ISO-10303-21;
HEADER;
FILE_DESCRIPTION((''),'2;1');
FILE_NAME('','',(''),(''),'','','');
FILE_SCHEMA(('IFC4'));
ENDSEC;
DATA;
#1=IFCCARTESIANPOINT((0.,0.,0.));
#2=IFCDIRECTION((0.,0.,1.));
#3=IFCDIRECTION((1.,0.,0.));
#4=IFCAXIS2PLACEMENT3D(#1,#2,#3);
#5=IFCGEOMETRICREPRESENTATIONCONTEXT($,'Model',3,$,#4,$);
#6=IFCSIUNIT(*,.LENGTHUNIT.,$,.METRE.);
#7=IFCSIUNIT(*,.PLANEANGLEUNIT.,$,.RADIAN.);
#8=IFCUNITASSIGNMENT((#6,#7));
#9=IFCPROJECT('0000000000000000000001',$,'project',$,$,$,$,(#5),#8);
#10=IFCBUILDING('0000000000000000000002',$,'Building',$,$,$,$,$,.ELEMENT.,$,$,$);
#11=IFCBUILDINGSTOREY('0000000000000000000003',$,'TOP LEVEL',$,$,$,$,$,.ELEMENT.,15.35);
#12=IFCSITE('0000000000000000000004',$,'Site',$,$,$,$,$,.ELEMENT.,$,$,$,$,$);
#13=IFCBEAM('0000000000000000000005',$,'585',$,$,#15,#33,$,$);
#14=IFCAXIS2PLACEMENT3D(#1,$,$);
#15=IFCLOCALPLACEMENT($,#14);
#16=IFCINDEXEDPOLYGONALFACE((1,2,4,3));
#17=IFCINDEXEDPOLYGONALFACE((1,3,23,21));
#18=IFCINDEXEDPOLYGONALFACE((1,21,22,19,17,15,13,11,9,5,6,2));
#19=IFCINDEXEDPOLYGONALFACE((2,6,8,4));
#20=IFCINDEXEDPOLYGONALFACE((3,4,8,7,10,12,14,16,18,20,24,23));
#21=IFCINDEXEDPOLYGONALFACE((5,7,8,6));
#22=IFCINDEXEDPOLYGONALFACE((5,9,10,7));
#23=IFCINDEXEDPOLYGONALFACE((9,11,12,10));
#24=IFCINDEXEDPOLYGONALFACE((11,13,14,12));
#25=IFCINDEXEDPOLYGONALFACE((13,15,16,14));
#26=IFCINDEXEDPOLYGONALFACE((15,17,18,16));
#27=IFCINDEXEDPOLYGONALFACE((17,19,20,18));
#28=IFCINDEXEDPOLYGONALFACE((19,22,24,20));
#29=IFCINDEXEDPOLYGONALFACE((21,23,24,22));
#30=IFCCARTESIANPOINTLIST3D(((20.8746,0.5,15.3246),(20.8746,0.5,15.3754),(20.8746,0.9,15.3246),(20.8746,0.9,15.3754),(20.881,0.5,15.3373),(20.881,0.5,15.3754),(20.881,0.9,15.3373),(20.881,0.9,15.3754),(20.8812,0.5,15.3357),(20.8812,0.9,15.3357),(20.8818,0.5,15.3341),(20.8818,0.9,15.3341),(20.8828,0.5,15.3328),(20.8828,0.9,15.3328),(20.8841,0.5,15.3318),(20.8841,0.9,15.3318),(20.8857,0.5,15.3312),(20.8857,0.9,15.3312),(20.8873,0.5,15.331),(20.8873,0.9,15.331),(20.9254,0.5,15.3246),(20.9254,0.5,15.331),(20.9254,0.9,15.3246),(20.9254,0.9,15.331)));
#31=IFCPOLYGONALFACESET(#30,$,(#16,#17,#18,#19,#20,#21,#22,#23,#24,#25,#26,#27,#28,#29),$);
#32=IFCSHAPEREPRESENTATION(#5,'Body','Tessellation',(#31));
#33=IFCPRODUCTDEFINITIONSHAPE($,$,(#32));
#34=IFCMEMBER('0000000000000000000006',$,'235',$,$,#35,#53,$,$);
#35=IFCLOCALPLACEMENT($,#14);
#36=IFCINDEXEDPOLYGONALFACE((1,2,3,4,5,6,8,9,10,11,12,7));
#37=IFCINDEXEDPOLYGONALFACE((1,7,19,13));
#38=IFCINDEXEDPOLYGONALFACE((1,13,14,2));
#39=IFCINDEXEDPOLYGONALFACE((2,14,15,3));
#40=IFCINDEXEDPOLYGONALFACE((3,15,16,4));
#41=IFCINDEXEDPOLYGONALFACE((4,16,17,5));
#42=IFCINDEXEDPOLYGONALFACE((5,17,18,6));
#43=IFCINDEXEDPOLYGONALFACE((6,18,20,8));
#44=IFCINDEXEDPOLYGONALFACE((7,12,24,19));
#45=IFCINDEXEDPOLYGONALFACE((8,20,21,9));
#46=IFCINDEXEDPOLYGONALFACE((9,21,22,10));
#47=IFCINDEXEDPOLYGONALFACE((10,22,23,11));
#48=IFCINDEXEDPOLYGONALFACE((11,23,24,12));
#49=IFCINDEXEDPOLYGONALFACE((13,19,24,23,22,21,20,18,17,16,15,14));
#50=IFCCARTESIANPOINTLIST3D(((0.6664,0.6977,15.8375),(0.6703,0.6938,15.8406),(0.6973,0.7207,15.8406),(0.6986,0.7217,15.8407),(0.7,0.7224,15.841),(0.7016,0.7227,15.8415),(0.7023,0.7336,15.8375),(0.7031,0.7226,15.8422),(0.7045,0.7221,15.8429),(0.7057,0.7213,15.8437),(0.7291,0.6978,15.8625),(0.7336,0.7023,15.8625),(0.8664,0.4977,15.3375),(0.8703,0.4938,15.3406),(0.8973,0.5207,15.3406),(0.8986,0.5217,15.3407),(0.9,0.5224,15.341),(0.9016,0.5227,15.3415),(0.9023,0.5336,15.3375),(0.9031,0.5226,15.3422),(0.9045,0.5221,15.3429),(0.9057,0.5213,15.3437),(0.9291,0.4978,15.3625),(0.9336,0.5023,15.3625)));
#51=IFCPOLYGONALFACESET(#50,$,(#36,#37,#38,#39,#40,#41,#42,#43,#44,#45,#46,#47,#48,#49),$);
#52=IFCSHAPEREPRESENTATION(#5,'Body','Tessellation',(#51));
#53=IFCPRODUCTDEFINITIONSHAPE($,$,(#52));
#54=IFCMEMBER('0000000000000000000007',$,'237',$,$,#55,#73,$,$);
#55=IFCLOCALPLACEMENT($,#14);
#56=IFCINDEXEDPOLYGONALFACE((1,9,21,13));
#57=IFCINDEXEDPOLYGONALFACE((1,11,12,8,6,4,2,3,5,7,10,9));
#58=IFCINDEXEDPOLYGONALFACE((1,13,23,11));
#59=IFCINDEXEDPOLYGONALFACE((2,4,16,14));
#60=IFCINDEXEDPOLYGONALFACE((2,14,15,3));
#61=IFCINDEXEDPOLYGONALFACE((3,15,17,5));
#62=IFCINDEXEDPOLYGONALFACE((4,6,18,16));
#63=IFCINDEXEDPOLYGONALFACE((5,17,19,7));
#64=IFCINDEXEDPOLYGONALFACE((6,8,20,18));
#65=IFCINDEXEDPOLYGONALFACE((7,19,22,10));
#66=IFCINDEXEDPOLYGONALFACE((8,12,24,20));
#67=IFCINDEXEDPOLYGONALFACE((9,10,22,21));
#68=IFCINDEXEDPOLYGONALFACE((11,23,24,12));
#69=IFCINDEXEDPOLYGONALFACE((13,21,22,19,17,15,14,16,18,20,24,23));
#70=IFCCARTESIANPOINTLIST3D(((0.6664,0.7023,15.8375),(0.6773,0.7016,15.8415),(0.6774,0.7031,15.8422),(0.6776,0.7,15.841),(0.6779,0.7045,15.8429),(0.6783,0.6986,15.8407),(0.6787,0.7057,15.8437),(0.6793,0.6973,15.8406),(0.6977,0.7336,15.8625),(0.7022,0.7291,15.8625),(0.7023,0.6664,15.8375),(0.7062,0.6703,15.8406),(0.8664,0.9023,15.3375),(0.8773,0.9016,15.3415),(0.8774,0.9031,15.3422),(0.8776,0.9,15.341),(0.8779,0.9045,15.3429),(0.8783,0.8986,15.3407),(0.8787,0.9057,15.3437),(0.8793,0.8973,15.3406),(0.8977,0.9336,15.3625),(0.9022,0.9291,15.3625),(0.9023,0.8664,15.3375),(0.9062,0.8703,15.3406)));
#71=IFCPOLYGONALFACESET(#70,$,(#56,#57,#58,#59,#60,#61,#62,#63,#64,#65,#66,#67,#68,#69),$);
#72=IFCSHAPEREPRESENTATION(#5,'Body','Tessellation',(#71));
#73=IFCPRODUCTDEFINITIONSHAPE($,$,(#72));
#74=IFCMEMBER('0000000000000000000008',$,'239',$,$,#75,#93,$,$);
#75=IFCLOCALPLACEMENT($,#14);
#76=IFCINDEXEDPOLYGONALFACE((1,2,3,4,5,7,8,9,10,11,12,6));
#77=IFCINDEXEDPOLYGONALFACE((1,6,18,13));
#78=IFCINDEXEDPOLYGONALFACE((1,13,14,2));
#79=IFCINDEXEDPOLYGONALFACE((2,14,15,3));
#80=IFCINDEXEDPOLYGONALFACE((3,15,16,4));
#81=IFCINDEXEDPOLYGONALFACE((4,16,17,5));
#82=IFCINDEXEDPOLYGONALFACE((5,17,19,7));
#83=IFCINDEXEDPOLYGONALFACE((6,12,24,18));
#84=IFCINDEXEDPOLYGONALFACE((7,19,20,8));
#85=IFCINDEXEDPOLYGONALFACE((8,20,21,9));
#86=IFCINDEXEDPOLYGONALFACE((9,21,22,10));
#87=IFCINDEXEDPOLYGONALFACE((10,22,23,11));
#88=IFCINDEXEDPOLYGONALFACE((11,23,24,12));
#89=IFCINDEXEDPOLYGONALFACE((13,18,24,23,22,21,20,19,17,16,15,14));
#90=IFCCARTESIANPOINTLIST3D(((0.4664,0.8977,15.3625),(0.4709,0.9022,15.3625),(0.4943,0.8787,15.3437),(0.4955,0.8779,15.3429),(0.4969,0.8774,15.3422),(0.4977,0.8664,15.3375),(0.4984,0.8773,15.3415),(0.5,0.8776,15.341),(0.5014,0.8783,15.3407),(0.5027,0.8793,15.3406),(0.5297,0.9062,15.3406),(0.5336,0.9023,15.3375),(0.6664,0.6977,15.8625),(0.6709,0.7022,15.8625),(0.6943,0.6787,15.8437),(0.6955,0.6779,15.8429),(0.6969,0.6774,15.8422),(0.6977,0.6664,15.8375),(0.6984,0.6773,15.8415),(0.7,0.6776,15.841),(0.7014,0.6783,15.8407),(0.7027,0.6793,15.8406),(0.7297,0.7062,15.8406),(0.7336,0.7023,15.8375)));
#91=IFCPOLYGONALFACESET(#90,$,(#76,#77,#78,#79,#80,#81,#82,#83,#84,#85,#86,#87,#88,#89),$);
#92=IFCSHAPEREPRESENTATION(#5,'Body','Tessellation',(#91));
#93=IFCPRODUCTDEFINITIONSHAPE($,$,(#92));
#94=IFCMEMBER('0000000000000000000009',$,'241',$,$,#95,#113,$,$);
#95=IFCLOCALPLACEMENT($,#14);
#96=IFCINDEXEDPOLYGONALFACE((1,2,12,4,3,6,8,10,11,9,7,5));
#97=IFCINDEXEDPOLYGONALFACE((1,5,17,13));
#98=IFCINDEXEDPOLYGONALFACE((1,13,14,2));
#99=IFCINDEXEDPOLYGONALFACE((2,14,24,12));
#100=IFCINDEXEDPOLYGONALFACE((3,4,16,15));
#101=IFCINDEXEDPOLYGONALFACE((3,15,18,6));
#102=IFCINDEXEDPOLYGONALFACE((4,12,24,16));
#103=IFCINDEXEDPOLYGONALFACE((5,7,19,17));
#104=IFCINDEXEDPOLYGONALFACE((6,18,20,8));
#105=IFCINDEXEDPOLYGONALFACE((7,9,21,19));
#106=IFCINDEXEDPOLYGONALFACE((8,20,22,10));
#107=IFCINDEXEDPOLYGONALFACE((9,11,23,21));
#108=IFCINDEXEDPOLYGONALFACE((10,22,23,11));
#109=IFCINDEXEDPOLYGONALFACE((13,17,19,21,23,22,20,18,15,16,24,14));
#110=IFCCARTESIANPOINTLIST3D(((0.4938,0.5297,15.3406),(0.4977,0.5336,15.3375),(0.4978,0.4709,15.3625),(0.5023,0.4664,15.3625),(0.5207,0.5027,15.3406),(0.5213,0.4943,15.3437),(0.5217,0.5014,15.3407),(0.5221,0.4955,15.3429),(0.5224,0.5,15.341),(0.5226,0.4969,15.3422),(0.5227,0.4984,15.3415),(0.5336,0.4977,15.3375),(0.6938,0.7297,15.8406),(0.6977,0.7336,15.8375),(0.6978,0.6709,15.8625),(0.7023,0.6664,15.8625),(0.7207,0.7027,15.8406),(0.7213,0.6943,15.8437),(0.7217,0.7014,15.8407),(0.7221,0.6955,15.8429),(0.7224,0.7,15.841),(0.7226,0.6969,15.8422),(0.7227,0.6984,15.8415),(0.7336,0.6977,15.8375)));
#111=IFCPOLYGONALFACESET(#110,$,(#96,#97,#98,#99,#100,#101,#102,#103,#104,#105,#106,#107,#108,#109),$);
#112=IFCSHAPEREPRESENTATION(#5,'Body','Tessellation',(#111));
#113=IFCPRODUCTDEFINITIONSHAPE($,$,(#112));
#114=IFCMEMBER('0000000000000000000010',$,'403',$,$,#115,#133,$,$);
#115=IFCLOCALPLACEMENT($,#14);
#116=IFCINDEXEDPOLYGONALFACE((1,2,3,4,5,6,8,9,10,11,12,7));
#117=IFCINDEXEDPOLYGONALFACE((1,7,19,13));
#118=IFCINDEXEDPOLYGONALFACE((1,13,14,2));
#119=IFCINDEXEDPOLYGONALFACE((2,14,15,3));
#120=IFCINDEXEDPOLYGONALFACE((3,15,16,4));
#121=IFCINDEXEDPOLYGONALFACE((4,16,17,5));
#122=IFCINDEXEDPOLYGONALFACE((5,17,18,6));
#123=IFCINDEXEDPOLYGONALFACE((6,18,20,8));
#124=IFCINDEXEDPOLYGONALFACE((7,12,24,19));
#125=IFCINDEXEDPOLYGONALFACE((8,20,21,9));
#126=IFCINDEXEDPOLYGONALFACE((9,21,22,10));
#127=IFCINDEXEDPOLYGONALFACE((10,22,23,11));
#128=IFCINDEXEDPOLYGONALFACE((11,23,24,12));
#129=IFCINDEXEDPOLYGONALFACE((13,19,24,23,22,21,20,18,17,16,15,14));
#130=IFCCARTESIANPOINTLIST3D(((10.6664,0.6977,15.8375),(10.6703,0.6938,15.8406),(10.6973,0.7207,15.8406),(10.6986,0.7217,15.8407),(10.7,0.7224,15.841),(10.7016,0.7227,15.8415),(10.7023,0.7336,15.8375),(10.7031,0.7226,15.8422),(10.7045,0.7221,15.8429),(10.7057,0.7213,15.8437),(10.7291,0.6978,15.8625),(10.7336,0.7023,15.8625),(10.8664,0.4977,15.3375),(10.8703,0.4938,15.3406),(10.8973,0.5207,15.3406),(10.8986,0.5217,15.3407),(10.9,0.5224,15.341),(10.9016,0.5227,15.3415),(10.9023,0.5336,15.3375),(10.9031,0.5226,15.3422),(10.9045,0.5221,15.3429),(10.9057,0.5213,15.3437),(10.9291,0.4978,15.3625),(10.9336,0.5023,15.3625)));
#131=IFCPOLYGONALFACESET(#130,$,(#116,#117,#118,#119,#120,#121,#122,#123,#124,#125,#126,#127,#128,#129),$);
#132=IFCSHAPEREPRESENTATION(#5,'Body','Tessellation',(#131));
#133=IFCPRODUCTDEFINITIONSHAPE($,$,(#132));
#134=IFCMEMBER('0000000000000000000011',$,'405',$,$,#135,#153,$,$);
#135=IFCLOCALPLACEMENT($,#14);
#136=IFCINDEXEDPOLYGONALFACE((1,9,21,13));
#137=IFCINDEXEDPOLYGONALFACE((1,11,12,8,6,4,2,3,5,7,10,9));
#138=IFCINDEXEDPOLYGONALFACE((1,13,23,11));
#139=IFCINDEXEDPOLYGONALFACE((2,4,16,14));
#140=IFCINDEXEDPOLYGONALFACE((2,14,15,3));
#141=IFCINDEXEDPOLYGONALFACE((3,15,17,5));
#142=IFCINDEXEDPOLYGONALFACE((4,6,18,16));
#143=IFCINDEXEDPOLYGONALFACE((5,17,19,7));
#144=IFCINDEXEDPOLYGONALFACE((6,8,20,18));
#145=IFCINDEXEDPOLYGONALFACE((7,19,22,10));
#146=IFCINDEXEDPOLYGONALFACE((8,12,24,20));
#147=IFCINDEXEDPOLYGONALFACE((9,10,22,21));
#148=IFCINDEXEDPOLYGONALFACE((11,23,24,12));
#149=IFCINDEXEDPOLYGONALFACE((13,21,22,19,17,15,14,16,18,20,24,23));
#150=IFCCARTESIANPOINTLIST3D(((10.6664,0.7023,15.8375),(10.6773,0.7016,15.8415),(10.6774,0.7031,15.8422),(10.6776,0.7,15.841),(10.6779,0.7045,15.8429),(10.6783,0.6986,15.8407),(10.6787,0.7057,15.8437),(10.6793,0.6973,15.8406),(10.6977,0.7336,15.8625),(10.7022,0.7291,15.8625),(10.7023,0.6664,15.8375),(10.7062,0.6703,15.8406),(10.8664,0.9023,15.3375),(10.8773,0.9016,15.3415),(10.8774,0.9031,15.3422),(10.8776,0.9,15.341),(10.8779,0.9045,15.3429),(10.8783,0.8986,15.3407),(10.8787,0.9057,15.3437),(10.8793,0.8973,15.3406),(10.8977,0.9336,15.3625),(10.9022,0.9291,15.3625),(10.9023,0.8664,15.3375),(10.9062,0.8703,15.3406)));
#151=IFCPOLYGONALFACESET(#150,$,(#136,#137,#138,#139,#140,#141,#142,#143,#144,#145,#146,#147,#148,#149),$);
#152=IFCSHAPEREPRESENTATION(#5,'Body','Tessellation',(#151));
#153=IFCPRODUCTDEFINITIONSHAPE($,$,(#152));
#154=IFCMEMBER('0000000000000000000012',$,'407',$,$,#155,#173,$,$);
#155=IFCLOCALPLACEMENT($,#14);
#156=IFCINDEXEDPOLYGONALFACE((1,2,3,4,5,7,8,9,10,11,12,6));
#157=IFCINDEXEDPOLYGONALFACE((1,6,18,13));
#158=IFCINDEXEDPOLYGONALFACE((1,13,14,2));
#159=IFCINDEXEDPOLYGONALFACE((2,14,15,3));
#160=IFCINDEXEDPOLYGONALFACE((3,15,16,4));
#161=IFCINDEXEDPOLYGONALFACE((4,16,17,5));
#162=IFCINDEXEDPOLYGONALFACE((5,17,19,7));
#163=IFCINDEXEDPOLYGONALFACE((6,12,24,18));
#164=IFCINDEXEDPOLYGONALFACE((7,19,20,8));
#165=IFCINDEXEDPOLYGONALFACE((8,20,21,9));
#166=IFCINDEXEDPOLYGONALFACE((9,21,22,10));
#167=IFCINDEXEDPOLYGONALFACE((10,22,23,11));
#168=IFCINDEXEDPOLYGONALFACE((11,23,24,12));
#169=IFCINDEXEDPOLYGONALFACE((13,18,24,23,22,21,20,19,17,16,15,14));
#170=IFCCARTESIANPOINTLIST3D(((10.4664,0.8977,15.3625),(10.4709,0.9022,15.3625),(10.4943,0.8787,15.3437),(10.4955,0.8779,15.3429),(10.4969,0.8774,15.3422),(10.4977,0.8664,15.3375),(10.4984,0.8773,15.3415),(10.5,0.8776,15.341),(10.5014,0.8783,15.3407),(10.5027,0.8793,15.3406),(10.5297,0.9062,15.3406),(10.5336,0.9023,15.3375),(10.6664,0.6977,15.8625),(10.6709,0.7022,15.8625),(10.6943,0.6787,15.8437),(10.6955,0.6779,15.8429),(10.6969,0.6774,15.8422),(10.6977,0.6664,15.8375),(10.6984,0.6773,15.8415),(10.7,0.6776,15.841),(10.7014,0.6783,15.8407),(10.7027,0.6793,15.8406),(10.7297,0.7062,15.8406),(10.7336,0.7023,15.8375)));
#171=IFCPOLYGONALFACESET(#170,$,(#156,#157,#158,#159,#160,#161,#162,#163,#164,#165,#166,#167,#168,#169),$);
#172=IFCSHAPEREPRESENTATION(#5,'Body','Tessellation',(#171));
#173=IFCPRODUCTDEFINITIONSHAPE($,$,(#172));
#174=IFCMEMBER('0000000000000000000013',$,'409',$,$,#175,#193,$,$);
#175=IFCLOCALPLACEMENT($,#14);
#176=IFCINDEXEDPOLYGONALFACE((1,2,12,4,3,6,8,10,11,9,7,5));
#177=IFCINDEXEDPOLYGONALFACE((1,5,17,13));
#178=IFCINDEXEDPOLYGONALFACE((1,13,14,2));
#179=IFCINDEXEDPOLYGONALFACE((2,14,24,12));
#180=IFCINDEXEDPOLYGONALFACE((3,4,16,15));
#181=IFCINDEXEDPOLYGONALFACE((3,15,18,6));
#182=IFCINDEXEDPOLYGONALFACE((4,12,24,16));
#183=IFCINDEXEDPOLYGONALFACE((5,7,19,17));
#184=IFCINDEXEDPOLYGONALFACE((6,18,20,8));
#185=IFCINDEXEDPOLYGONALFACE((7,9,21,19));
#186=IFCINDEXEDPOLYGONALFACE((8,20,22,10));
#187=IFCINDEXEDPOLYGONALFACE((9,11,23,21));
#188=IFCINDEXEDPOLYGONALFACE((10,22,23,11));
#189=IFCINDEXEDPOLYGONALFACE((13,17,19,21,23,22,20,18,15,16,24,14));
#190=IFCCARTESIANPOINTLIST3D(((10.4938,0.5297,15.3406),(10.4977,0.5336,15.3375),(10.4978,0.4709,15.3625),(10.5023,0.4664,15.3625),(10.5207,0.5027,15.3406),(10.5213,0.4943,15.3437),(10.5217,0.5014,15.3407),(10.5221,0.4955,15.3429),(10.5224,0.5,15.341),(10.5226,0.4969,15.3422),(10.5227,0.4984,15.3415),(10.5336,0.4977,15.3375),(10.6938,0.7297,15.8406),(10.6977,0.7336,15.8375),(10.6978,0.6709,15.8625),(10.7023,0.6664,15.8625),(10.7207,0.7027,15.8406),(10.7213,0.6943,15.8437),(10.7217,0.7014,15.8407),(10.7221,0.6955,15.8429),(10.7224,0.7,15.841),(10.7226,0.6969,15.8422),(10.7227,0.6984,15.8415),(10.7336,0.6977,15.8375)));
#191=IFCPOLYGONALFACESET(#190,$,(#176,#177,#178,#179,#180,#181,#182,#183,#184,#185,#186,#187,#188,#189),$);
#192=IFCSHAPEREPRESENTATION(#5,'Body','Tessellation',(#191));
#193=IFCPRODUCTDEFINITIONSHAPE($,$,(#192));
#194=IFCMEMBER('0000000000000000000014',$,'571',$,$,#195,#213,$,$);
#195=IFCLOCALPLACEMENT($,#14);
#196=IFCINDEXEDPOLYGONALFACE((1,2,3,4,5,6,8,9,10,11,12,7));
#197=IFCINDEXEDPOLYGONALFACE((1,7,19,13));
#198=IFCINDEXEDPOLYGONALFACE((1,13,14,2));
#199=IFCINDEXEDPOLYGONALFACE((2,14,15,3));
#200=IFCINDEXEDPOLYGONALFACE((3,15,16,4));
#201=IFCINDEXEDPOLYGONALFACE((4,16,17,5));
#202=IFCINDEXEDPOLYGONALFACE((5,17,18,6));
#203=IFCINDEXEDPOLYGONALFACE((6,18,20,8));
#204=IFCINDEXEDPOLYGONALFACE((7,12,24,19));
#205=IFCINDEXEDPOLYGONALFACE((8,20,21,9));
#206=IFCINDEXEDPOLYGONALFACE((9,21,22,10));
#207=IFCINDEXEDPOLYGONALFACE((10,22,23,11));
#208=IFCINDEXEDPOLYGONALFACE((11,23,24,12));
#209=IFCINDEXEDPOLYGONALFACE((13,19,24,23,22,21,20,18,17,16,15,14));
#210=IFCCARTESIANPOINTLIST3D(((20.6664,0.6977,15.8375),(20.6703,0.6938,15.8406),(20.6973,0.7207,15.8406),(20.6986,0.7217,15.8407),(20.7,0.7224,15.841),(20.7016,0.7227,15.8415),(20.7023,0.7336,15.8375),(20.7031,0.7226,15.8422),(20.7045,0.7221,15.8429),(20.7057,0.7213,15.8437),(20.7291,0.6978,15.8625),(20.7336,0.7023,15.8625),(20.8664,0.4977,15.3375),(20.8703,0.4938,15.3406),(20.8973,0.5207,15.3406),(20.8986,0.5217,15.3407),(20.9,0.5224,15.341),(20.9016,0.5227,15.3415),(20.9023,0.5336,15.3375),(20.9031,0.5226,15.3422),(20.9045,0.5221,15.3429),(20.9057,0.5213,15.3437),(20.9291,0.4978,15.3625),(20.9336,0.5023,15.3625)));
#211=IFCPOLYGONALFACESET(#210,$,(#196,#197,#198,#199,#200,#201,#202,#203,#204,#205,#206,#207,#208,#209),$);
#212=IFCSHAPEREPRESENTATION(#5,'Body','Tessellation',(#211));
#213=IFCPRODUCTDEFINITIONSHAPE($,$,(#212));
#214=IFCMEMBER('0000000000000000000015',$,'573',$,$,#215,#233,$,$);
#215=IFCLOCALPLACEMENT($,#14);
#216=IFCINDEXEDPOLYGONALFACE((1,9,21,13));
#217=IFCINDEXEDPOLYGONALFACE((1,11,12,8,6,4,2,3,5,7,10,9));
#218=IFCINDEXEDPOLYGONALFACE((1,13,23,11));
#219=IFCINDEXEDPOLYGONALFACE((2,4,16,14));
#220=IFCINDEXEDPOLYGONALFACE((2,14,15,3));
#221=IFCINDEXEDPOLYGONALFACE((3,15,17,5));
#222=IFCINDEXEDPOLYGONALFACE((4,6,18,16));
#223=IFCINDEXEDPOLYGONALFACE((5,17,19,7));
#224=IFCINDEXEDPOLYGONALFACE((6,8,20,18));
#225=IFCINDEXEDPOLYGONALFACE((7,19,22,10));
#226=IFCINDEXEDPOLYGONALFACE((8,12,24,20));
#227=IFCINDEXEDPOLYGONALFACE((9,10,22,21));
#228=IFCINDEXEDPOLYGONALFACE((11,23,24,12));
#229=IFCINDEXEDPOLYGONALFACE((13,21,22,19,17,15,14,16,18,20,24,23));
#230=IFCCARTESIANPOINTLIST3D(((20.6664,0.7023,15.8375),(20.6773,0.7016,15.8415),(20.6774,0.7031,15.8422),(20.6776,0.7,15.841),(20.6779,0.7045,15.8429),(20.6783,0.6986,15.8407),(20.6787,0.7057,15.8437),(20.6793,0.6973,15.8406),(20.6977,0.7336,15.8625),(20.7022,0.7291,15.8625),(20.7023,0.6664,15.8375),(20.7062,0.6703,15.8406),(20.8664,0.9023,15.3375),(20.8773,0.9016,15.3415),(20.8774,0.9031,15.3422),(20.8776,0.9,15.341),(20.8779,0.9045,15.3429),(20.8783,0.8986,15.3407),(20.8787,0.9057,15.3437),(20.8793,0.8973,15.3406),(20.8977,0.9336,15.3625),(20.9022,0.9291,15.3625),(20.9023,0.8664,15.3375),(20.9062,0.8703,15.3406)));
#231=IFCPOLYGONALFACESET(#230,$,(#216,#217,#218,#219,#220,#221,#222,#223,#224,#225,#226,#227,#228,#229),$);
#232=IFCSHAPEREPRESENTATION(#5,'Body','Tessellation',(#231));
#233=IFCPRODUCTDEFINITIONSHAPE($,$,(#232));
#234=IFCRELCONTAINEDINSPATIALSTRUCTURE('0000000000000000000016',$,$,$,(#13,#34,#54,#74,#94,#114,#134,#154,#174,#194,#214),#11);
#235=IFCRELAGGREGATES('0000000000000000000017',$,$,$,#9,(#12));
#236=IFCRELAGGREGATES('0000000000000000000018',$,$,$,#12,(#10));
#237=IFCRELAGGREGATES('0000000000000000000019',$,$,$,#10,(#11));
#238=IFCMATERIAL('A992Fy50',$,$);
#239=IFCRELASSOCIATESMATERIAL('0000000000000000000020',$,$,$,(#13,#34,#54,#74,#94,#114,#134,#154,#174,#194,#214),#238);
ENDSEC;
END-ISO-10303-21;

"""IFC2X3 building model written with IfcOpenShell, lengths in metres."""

from ifc_helpers import new_model, si_unit, frame, origin_with_axes, origin_2d_with_axis, place, context, project, spatial, l_section, extrude, material, element, save


model = new_model("IFC2X3")

# Units and contexts
model_context = context("Model", 3, world=origin_with_axes())
ifc_project = project(units=[si_unit("LENGTHUNIT", "METRE"), si_unit("PLANEANGLEUNIT", "RADIAN")], contexts=[model_context])

# Site, building, storey
site = spatial("IfcSite", under=ifc_project, Name="Site", CompositionType="ELEMENT")
building = spatial("IfcBuilding", under=site, Name="Building", CompositionType="ELEMENT")
storey = spatial("IfcBuildingStorey", under=building, Name="TOP LEVEL", CompositionType="ELEMENT", Elevation=15.35)

# Beam
ifc_material = material(Name="A992Fy50")
for number, where, z_axis, x_axis, name in (
    (1, (20.9, 0.9, 15.35), (0.0, -1.0, 0.0), (1.0, 0.0, 0.0), "585"),
):
    element("IfcBeam", number, at=place(None, frame(where, z_axis=z_axis, x_axis=x_axis)), inside=storey, material=ifc_material, Name=name, context=model_context, shape_type="SweptSolid", body=[
        extrude(l_section(Depth=0.0508, Width=0.0508, Thickness=0.0063, FilletRadius=0.0063, at=origin_2d_with_axis()), origin_with_axes(), (0.0, 0.0, 1.0), 0.4),
    ])

# Members
for number, where, z_axis, x_axis, name in (
    (2, (0.9, 0.5, 15.35), (-0.348155, 0.348155, 0.870388), (-0.707107, -0.707107, 0.0), "235"),
    (3, (0.9, 0.9, 15.35), (-0.348155, -0.348155, 0.870388), (0.707107, -0.707107, 0.0), "237"),
    (4, (0.5, 0.9, 15.35), (0.348155, -0.348155, 0.870388), (0.707107, 0.707107, 0.0), "239"),
    (5, (0.5, 0.5, 15.35), (0.348155, 0.348155, 0.870388), (-0.707107, 0.707107, 0.0), "241"),
    (6, (10.9, 0.5, 15.35), (-0.348155, 0.348155, 0.870388), (-0.707107, -0.707107, 0.0), "403"),
    (7, (10.9, 0.9, 15.35), (-0.348155, -0.348155, 0.870388), (0.707107, -0.707107, 0.0), "405"),
    (8, (10.5, 0.9, 15.35), (0.348155, -0.348155, 0.870388), (0.707107, 0.707107, 0.0), "407"),
    (9, (10.5, 0.5, 15.35), (0.348155, 0.348155, 0.870388), (-0.707107, 0.707107, 0.0), "409"),
    (10, (20.9, 0.5, 15.35), (-0.348155, 0.348155, 0.870388), (-0.707107, -0.707107, 0.0), "571"),
    (11, (20.9, 0.9, 15.35), (-0.348155, -0.348155, 0.870388), (0.707107, -0.707107, 0.0), "573"),
):
    element("IfcMember", number, at=place(None, frame(where, z_axis=z_axis, x_axis=x_axis)), inside=storey, material=ifc_material, Name=name, context=model_context, shape_type="SweptSolid", body=[
        extrude(l_section(Depth=0.0508, Width=0.0508, Thickness=0.0063, FilletRadius=0.0063, at=origin_2d_with_axis()), origin_with_axes(), (0.0, 0.0, 1.0), 0.5745),
    ])

save(model, "model.ifc")
